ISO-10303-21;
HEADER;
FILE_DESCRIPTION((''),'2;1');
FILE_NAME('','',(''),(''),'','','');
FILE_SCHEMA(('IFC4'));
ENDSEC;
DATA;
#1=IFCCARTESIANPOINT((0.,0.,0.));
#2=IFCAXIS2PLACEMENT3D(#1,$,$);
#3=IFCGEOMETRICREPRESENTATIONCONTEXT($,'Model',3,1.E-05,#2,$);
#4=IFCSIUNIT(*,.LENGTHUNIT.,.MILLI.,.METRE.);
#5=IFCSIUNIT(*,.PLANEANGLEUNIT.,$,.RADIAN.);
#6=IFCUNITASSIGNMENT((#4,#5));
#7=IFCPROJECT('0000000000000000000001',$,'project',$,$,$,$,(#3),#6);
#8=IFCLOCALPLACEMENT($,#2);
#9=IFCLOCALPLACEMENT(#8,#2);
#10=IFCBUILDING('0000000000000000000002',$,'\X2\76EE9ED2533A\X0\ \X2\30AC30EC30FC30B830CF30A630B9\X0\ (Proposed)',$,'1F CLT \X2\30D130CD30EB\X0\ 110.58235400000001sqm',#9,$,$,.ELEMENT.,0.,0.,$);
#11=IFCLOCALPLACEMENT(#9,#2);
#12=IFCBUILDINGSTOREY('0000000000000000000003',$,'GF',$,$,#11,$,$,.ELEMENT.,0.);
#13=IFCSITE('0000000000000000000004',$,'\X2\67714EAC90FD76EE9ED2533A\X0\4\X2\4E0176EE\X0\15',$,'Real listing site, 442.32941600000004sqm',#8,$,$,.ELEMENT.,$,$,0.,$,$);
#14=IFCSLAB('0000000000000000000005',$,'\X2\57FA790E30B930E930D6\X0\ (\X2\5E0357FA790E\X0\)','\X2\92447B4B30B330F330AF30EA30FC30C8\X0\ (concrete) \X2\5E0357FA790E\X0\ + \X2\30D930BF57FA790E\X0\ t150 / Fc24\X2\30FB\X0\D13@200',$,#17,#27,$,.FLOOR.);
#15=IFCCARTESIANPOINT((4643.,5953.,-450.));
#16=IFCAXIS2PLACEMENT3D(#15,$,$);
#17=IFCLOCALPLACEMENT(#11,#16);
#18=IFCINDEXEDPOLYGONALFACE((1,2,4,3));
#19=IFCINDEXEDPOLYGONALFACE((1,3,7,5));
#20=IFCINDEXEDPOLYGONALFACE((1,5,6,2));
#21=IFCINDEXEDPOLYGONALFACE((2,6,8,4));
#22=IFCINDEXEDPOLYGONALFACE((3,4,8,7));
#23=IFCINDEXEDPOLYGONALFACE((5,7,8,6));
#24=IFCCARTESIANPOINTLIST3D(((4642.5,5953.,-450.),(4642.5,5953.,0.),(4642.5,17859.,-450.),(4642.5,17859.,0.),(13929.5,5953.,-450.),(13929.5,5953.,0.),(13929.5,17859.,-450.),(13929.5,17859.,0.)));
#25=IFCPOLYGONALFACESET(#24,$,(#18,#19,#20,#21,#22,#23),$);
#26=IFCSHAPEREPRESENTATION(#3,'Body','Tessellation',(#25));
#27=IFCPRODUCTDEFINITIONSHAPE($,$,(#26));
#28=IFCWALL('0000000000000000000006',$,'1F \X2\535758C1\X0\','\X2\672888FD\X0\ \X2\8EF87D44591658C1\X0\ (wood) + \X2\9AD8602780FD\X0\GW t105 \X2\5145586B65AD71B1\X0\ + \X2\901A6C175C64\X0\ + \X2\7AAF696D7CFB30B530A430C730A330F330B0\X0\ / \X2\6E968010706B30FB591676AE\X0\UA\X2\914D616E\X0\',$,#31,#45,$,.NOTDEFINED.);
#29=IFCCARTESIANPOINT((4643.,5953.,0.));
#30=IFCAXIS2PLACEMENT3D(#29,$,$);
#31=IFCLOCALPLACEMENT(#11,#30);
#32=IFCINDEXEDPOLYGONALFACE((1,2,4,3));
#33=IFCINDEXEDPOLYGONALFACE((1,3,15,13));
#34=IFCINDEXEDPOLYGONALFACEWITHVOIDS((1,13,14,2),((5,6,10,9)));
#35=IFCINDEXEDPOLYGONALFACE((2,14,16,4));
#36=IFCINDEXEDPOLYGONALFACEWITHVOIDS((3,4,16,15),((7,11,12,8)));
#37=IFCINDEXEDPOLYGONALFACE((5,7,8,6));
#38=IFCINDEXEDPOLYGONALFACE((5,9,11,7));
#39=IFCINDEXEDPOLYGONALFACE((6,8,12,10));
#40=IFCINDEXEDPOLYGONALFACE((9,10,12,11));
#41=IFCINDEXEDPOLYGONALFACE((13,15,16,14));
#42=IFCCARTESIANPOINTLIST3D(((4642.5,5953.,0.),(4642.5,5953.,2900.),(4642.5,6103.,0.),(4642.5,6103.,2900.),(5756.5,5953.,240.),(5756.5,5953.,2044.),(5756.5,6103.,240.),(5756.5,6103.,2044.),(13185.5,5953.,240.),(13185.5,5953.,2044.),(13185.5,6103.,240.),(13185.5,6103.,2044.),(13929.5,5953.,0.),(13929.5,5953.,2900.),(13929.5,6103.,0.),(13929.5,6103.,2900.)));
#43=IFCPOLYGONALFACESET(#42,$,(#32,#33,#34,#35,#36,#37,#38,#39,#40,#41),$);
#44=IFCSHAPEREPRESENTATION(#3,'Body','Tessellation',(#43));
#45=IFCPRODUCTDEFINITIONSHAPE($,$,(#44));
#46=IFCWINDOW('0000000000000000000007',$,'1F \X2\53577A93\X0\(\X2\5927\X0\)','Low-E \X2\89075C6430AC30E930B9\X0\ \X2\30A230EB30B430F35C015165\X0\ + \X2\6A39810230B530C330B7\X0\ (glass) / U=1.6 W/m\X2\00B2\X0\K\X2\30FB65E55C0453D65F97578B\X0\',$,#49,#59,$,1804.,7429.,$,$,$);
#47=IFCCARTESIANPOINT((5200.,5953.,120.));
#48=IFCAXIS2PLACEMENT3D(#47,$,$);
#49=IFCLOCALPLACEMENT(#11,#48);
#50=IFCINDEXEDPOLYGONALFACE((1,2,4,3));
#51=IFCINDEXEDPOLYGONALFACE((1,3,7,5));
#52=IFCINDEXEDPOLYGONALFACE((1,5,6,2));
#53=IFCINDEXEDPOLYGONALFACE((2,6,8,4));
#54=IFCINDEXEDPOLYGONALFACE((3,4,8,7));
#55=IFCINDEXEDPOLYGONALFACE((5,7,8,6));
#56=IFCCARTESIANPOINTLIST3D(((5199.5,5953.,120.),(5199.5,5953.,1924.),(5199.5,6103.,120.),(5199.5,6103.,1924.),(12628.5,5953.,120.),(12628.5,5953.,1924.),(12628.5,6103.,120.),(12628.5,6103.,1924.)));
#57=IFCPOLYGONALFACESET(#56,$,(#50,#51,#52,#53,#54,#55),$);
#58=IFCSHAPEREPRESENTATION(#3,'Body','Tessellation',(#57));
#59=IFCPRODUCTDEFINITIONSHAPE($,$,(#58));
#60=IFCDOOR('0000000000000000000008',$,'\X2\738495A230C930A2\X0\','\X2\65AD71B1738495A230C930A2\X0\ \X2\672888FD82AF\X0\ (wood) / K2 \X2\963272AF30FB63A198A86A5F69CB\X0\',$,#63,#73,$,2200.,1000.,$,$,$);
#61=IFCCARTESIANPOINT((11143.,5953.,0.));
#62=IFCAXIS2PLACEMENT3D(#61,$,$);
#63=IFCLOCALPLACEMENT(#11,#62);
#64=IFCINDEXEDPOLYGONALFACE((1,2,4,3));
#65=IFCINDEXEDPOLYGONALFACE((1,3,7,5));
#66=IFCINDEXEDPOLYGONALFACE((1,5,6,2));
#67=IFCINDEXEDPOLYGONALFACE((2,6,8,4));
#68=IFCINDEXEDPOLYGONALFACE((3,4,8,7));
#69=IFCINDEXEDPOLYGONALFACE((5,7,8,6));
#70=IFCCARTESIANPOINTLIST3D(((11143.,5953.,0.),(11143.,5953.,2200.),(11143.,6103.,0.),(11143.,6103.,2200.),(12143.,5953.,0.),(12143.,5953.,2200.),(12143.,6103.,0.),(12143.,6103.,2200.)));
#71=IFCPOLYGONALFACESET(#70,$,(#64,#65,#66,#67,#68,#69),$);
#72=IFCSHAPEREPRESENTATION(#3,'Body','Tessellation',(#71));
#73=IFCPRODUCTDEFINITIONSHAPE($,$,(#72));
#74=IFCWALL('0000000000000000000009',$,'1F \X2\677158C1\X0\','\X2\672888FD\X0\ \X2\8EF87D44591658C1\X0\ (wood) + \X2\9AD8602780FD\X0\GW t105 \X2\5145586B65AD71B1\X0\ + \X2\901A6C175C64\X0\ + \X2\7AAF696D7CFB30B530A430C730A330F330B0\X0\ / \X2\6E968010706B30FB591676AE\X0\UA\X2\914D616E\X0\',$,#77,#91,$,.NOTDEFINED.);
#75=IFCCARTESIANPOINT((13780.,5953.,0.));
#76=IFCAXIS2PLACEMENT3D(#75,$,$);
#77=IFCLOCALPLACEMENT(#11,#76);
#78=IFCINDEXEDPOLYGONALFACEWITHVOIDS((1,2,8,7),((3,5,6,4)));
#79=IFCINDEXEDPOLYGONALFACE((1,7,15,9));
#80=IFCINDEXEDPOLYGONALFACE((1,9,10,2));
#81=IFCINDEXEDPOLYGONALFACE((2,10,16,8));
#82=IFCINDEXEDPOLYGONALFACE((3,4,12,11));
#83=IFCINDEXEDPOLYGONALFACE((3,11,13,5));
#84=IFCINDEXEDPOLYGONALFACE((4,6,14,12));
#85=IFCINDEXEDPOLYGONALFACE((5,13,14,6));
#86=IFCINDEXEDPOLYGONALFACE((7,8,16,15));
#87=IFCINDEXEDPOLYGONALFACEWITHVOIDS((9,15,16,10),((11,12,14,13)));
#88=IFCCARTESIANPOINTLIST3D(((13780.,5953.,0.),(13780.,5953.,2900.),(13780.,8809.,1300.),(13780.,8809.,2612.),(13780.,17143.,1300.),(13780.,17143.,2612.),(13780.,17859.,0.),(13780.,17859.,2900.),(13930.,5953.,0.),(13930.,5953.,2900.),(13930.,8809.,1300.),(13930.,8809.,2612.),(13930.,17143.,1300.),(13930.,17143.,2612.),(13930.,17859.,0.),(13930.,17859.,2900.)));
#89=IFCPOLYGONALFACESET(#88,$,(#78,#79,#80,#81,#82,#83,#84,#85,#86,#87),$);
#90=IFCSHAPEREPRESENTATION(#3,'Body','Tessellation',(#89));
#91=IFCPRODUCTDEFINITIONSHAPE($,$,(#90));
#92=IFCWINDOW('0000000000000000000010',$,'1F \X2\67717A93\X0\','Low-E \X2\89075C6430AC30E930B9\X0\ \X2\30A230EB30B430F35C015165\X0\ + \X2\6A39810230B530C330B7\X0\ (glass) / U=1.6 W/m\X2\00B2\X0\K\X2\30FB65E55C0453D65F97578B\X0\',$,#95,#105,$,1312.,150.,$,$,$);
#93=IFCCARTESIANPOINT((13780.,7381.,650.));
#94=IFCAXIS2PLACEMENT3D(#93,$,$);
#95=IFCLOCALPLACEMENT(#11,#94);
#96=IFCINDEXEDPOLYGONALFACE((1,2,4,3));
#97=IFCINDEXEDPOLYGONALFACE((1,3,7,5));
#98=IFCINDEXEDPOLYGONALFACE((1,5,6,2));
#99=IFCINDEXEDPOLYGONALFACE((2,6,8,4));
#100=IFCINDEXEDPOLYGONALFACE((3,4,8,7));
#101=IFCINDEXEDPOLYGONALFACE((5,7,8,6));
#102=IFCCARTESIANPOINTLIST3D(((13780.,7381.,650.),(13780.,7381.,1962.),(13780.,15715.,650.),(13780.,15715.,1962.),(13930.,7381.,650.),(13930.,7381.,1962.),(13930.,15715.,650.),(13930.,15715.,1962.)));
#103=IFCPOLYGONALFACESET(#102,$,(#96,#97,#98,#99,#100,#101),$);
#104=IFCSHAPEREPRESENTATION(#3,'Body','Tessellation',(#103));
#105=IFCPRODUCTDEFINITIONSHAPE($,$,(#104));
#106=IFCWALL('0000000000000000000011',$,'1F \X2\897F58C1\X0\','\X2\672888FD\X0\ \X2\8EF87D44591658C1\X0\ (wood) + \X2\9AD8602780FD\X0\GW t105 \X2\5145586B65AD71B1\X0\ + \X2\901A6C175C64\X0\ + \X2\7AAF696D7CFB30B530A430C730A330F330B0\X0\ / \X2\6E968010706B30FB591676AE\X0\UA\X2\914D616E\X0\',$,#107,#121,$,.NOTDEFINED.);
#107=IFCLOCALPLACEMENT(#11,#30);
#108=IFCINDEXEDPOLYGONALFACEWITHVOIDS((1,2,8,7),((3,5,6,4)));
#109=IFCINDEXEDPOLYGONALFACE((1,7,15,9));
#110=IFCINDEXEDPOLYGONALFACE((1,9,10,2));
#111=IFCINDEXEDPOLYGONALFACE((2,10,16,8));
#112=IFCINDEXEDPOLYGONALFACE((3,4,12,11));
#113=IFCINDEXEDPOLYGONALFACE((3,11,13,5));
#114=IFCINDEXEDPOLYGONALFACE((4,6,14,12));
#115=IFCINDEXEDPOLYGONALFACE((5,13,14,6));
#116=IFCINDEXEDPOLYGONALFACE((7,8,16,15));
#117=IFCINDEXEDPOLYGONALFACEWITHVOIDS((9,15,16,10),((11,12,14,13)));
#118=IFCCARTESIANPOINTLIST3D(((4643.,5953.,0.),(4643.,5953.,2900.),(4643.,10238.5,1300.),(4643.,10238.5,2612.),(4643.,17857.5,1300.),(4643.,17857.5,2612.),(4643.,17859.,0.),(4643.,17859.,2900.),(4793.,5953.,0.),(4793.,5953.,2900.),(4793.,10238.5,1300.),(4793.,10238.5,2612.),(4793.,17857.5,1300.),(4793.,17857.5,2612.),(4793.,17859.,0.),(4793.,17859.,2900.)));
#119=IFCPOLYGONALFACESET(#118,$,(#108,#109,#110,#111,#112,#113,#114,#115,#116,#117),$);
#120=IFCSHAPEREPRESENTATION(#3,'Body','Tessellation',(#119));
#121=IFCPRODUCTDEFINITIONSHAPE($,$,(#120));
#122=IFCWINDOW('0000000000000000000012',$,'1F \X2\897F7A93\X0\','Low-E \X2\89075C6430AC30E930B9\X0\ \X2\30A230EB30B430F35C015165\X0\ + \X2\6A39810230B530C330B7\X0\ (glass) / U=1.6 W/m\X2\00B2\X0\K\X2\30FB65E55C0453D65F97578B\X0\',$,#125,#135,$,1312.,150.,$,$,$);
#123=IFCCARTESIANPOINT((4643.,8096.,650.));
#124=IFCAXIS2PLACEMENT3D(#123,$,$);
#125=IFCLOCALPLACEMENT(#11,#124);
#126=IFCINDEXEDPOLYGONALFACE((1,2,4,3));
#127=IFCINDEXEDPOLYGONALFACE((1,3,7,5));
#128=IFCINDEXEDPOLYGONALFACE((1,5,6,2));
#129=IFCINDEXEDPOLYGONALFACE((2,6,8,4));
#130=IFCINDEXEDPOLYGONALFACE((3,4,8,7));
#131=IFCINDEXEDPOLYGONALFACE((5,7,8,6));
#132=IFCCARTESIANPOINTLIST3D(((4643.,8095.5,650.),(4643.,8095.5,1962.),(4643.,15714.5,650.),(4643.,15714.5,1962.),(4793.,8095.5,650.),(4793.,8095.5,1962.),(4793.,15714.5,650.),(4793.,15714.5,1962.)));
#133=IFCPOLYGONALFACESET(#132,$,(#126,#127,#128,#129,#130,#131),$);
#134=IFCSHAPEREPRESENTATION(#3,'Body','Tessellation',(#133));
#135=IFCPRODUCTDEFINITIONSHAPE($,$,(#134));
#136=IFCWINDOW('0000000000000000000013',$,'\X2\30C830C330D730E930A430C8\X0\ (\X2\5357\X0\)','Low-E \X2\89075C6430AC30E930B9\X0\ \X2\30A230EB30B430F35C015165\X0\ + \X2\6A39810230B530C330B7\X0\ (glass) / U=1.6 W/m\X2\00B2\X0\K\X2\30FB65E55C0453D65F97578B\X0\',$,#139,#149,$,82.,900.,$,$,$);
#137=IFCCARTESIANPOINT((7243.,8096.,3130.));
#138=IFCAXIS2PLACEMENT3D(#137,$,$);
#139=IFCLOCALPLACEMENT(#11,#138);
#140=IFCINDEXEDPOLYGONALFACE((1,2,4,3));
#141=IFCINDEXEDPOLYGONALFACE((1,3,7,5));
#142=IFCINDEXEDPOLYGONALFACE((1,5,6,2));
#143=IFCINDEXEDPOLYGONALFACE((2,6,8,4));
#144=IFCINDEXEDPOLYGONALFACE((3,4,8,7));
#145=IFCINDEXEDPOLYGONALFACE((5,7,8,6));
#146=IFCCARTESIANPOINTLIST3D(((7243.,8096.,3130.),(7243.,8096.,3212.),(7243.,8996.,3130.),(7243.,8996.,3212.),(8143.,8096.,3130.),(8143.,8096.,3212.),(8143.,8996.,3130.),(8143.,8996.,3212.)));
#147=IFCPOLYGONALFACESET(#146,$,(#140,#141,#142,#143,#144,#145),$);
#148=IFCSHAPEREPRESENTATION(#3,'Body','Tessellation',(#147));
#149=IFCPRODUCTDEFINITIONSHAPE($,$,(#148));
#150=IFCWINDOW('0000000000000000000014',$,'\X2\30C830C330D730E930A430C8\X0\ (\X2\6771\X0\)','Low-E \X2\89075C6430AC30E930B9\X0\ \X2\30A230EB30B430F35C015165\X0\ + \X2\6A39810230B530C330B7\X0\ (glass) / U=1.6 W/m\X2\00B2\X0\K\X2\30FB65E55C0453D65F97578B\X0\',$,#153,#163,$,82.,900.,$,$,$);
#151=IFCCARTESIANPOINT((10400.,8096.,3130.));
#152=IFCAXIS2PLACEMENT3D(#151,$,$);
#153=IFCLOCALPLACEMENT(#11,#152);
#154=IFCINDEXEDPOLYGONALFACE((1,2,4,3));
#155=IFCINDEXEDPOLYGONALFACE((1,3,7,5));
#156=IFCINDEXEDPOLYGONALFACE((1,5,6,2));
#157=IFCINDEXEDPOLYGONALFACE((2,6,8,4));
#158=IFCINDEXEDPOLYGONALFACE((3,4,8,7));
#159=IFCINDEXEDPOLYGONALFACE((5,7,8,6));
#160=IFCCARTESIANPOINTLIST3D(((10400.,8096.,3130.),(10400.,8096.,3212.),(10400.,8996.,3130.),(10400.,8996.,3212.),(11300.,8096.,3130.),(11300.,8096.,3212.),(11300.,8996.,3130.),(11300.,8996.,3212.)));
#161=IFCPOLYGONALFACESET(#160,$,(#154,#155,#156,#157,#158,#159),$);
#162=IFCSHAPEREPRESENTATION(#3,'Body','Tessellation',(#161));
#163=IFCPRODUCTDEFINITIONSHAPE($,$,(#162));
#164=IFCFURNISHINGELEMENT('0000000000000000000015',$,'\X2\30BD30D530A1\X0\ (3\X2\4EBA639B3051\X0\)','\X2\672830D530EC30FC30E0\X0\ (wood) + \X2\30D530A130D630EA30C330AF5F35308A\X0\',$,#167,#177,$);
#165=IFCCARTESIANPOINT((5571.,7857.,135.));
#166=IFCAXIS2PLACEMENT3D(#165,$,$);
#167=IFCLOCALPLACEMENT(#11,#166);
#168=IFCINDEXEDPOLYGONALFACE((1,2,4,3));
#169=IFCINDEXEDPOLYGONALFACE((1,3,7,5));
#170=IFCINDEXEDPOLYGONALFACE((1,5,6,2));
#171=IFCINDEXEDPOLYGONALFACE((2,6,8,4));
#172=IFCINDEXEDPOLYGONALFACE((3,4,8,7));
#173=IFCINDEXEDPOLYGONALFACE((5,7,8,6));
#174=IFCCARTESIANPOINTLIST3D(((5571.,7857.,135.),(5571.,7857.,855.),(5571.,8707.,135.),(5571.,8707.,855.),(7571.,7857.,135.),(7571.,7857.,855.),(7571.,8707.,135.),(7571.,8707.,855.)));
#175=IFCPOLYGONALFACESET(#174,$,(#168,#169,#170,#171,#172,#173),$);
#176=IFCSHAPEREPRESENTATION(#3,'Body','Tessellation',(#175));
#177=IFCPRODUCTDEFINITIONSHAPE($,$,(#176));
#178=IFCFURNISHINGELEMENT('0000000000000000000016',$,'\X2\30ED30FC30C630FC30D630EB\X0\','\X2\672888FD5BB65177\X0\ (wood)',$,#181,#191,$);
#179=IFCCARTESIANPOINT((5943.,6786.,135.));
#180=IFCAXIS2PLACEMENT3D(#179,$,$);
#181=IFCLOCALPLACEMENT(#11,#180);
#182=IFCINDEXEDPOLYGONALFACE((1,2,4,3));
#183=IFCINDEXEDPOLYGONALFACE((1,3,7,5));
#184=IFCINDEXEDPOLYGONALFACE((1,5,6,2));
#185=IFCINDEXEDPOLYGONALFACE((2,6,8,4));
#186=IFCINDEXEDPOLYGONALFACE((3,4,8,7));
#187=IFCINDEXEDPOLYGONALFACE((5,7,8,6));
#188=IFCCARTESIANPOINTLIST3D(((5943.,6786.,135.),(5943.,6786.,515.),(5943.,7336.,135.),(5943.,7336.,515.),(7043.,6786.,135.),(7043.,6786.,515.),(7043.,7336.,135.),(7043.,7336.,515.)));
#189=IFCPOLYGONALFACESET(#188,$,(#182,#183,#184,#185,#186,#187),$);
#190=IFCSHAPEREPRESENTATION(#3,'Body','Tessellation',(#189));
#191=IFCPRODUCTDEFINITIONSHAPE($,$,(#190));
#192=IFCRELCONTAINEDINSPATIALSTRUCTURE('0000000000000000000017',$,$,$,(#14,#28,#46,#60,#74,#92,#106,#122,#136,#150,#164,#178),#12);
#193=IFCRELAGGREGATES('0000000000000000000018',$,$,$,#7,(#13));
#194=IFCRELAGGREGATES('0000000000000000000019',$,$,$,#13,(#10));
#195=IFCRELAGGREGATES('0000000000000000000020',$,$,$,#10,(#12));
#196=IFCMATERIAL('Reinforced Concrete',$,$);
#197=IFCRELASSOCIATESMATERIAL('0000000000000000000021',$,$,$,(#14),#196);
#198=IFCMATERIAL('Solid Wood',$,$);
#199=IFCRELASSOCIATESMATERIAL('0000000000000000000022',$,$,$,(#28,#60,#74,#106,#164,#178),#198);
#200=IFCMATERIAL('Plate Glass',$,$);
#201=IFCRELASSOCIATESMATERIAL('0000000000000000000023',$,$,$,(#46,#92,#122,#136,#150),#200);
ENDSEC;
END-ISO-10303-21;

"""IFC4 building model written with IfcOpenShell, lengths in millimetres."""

from ifc_helpers import new_model, si_unit, frame, frame_2d, origin, place, context, project, spatial, rectangle, extrude, material, element, fill, save


model = new_model("IFC4")

# Units and contexts
model_context = context("Model", 3, precision=1e-05, world=origin())
ifc_project = project(units=[si_unit("LENGTHUNIT", "METRE", prefix="MILLI"), si_unit("PLANEANGLEUNIT", "RADIAN")], contexts=[model_context])

# Site, building, storey
site_placement = place(None, origin())
site = spatial("IfcSite", under=ifc_project, at=site_placement, Name="東京都目黒区4丁目15", ObjectType="Real listing site, 442.32941600000004sqm", CompositionType="ELEMENT", RefElevation=0.0)
building_placement = place(site_placement, origin())
building = spatial("IfcBuilding", under=site, at=building_placement, Name="目黒区 ガレージハウス (Proposed)", ObjectType="1F CLT パネル 110.58235400000001sqm", CompositionType="ELEMENT", ElevationOfRefHeight=0.0, ElevationOfTerrain=0.0)
storey_placement = place(building_placement, origin())
storey = spatial("IfcBuildingStorey", under=building, at=storey_placement, Name="GF", CompositionType="ELEMENT", Elevation=0.0)

# Slab
ifc_material_1 = material(Name="Reinforced Concrete")
slab_1_placement = place(storey_placement, frame((4643.0, 5953.0, -450.0)))
element("IfcSlab", 1, at=slab_1_placement, inside=storey, material=ifc_material_1, Name="基礎スラブ (布基礎)", Description="鉄筋コンクリート (concrete) 布基礎 + ベタ基礎 t150 / Fc24・D13@200", PredefinedType="FLOOR", context=model_context, shape_type="SweptSolid", body=[
    extrude(rectangle(XDim=9287.0, YDim=11906.0, at=frame_2d((4643.0, 5953.0))), frame((4643.0, 5953.0, -450.0)), (0.0, 0.0, 1.0), 450.0),
])
ifc_material_2 = material(Name="Solid Wood")

# Wall, openings, window, door
wall_1_placement = place(storey_placement, frame((4643.0, 5953.0, 0.0)))
wall_1 = element("IfcWall", 2, at=wall_1_placement, inside=storey, material=ifc_material_2, Name="1F 南壁", Description="木製 軸組外壁 (wood) + 高性能GW t105 充填断熱 + 通気層 + 窯業系サイディング / 準耐火・外皮UA配慮", PredefinedType="NOTDEFINED", context=model_context, shape_type="SweptSolid", body=[
    extrude(rectangle(XDim=9287.0, YDim=150.0, at=frame_2d((4643.0, 75.0))), frame((4643.0, 5953.0, 0.0)), (0.0, 0.0, 1.0), 2900.0),
])
opening_1_placement = place(storey_placement, frame((5200.0, 5953.0, 120.0)))
opening_1 = element("IfcOpeningElement", 3, at=opening_1_placement, cuts=wall_1, PredefinedType="NOTDEFINED", context=model_context, shape_type="SweptSolid", body=[
    extrude(rectangle(XDim=7429.0, YDim=150.0, at=frame_2d((3714.0, 75.0))), frame((5200.0, 5953.0, 120.0)), (0.0, 0.0, 1.0), 1804.0),
])
opening_2_placement = place(storey_placement, frame((11143.0, 5953.0, 0.0)))
opening_2 = element("IfcOpeningElement", 4, at=opening_2_placement, cuts=wall_1, PredefinedType="NOTDEFINED", context=model_context, shape_type="SweptSolid", body=[
    extrude(rectangle(XDim=1000.0, YDim=150.0, at=frame_2d((500.0, 75.0))), frame((11143.0, 5953.0, 0.0)), (0.0, 0.0, 1.0), 2200.0),
])
ifc_material_3 = material(Name="Plate Glass")
window_1_placement = place(storey_placement, frame((5200.0, 5953.0, 120.0)))
window_1 = element("IfcWindow", 5, at=window_1_placement, inside=storey, material=ifc_material_3, Name="1F 南窓(大)", Description="Low-E 複層ガラス アルゴン封入 + 樹脂サッシ (glass) / U=1.6 W/m²K・日射取得型", OverallHeight=1804.0, OverallWidth=7429.0, context=model_context, shape_type="SweptSolid", body=[
    extrude(rectangle(XDim=7429.0, YDim=150.0, at=frame_2d((3714.0, 75.0))), frame((5200.0, 5953.0, 120.0)), (0.0, 0.0, 1.0), 1804.0),
])
fill(opening_1, window_1)
door_placement = place(storey_placement, frame((11143.0, 5953.0, 0.0)))
door = element("IfcDoor", 6, at=door_placement, inside=storey, material=ifc_material_2, Name="玄関ドア", Description="断熱玄関ドア 木製芯 (wood) / K2 防犯・採風機構", OverallHeight=2200.0, OverallWidth=1000.0, context=model_context, shape_type="SweptSolid", body=[
    extrude(rectangle(XDim=1000.0, YDim=150.0, at=frame_2d((500.0, 75.0))), frame((11143.0, 5953.0, 0.0)), (0.0, 0.0, 1.0), 2200.0),
])
fill(opening_2, door)

# Walls, openings, windows
wall_2_placement = place(storey_placement, frame((13780.0, 5953.0, 0.0)))
wall_2 = element("IfcWall", 7, at=wall_2_placement, inside=storey, material=ifc_material_2, Name="1F 東壁", Description="木製 軸組外壁 (wood) + 高性能GW t105 充填断熱 + 通気層 + 窯業系サイディング / 準耐火・外皮UA配慮", PredefinedType="NOTDEFINED", context=model_context, shape_type="SweptSolid", body=[
    extrude(rectangle(XDim=150.0, YDim=11906.0, at=frame_2d((75.0, 5953.0))), frame((13780.0, 5953.0, 0.0)), (0.0, 0.0, 1.0), 2900.0),
])
opening_3_placement = place(storey_placement, frame((13780.0, 7381.0, 650.0)))
opening_3 = element("IfcOpeningElement", 8, at=opening_3_placement, cuts=wall_2, PredefinedType="NOTDEFINED", context=model_context, shape_type="SweptSolid", body=[
    extrude(rectangle(XDim=150.0, YDim=8334.0, at=frame_2d((75.0, 4167.0))), frame((13780.0, 7381.0, 650.0)), (0.0, 0.0, 1.0), 1312.0),
])
window_2_placement = place(storey_placement, frame((13780.0, 7381.0, 650.0)))
window_2 = element("IfcWindow", 9, at=window_2_placement, inside=storey, material=ifc_material_3, Name="1F 東窓", Description="Low-E 複層ガラス アルゴン封入 + 樹脂サッシ (glass) / U=1.6 W/m²K・日射取得型", OverallHeight=1312.0, OverallWidth=150.0, context=model_context, shape_type="SweptSolid", body=[
    extrude(rectangle(XDim=150.0, YDim=8334.0, at=frame_2d((75.0, 4167.0))), frame((13780.0, 7381.0, 650.0)), (0.0, 0.0, 1.0), 1312.0),
])
fill(opening_3, window_2)
wall_3_placement = place(storey_placement, frame((4643.0, 5953.0, 0.0)))
wall_3 = element("IfcWall", 10, at=wall_3_placement, inside=storey, material=ifc_material_2, Name="1F 西壁", Description="木製 軸組外壁 (wood) + 高性能GW t105 充填断熱 + 通気層 + 窯業系サイディング / 準耐火・外皮UA配慮", PredefinedType="NOTDEFINED", context=model_context, shape_type="SweptSolid", body=[
    extrude(rectangle(XDim=150.0, YDim=11906.0, at=frame_2d((75.0, 5953.0))), frame((4643.0, 5953.0, 0.0)), (0.0, 0.0, 1.0), 2900.0),
])
opening_4_placement = place(storey_placement, frame((4643.0, 8096.0, 650.0)))
opening_4 = element("IfcOpeningElement", 11, at=opening_4_placement, cuts=wall_3, PredefinedType="NOTDEFINED", context=model_context, shape_type="SweptSolid", body=[
    extrude(rectangle(XDim=150.0, YDim=7619.0, at=frame_2d((75.0, 3809.0))), frame((4643.0, 8096.0, 650.0)), (0.0, 0.0, 1.0), 1312.0),
])
window_3_placement = place(storey_placement, frame((4643.0, 8096.0, 650.0)))
window_3 = element("IfcWindow", 12, at=window_3_placement, inside=storey, material=ifc_material_3, Name="1F 西窓", Description="Low-E 複層ガラス アルゴン封入 + 樹脂サッシ (glass) / U=1.6 W/m²K・日射取得型", OverallHeight=1312.0, OverallWidth=150.0, context=model_context, shape_type="SweptSolid", body=[
    extrude(rectangle(XDim=150.0, YDim=7619.0, at=frame_2d((75.0, 3809.0))), frame((4643.0, 8096.0, 650.0)), (0.0, 0.0, 1.0), 1312.0),
])
fill(opening_4, window_3)

# Windows
window_4_placement = place(storey_placement, frame((7243.0, 8096.0, 3130.0)))
element("IfcWindow", 13, at=window_4_placement, inside=storey, material=ifc_material_3, Name="トップライト (南)", Description="Low-E 複層ガラス アルゴン封入 + 樹脂サッシ (glass) / U=1.6 W/m²K・日射取得型", OverallHeight=82.0, OverallWidth=900.0, context=model_context, shape_type="SweptSolid", body=[
    extrude(rectangle(XDim=900.0, YDim=900.0, at=frame_2d((450.0, 450.0))), frame((7243.0, 8096.0, 3130.0)), (0.0, 0.0, 1.0), 82.0),
])
window_5_placement = place(storey_placement, frame((10400.0, 8096.0, 3130.0)))
element("IfcWindow", 14, at=window_5_placement, inside=storey, material=ifc_material_3, Name="トップライト (東)", Description="Low-E 複層ガラス アルゴン封入 + 樹脂サッシ (glass) / U=1.6 W/m²K・日射取得型", OverallHeight=82.0, OverallWidth=900.0, context=model_context, shape_type="SweptSolid", body=[
    extrude(rectangle(XDim=900.0, YDim=900.0, at=frame_2d((450.0, 450.0))), frame((10400.0, 8096.0, 3130.0)), (0.0, 0.0, 1.0), 82.0),
])

# Furnishing elements
furnishing_1_placement = place(storey_placement, frame((5571.0, 7857.0, 135.0)))
element("IfcFurnishingElement", 15, at=furnishing_1_placement, inside=storey, material=ifc_material_2, Name="ソファ (3人掛け)", Description="木フレーム (wood) + ファブリック張り", context=model_context, shape_type="SweptSolid", body=[
    extrude(rectangle(XDim=2000.0, YDim=850.0, at=frame_2d((1000.0, 425.0))), frame((5571.0, 7857.0, 135.0)), (0.0, 0.0, 1.0), 720.0),
])
furnishing_2_placement = place(storey_placement, frame((5943.0, 6786.0, 135.0)))
element("IfcFurnishingElement", 16, at=furnishing_2_placement, inside=storey, material=ifc_material_2, Name="ローテーブル", Description="木製家具 (wood)", context=model_context, shape_type="SweptSolid", body=[
    extrude(rectangle(XDim=1100.0, YDim=550.0, at=frame_2d((550.0, 275.0))), frame((5943.0, 6786.0, 135.0)), (0.0, 0.0, 1.0), 380.0),
])

save(model, "model.ifc")
